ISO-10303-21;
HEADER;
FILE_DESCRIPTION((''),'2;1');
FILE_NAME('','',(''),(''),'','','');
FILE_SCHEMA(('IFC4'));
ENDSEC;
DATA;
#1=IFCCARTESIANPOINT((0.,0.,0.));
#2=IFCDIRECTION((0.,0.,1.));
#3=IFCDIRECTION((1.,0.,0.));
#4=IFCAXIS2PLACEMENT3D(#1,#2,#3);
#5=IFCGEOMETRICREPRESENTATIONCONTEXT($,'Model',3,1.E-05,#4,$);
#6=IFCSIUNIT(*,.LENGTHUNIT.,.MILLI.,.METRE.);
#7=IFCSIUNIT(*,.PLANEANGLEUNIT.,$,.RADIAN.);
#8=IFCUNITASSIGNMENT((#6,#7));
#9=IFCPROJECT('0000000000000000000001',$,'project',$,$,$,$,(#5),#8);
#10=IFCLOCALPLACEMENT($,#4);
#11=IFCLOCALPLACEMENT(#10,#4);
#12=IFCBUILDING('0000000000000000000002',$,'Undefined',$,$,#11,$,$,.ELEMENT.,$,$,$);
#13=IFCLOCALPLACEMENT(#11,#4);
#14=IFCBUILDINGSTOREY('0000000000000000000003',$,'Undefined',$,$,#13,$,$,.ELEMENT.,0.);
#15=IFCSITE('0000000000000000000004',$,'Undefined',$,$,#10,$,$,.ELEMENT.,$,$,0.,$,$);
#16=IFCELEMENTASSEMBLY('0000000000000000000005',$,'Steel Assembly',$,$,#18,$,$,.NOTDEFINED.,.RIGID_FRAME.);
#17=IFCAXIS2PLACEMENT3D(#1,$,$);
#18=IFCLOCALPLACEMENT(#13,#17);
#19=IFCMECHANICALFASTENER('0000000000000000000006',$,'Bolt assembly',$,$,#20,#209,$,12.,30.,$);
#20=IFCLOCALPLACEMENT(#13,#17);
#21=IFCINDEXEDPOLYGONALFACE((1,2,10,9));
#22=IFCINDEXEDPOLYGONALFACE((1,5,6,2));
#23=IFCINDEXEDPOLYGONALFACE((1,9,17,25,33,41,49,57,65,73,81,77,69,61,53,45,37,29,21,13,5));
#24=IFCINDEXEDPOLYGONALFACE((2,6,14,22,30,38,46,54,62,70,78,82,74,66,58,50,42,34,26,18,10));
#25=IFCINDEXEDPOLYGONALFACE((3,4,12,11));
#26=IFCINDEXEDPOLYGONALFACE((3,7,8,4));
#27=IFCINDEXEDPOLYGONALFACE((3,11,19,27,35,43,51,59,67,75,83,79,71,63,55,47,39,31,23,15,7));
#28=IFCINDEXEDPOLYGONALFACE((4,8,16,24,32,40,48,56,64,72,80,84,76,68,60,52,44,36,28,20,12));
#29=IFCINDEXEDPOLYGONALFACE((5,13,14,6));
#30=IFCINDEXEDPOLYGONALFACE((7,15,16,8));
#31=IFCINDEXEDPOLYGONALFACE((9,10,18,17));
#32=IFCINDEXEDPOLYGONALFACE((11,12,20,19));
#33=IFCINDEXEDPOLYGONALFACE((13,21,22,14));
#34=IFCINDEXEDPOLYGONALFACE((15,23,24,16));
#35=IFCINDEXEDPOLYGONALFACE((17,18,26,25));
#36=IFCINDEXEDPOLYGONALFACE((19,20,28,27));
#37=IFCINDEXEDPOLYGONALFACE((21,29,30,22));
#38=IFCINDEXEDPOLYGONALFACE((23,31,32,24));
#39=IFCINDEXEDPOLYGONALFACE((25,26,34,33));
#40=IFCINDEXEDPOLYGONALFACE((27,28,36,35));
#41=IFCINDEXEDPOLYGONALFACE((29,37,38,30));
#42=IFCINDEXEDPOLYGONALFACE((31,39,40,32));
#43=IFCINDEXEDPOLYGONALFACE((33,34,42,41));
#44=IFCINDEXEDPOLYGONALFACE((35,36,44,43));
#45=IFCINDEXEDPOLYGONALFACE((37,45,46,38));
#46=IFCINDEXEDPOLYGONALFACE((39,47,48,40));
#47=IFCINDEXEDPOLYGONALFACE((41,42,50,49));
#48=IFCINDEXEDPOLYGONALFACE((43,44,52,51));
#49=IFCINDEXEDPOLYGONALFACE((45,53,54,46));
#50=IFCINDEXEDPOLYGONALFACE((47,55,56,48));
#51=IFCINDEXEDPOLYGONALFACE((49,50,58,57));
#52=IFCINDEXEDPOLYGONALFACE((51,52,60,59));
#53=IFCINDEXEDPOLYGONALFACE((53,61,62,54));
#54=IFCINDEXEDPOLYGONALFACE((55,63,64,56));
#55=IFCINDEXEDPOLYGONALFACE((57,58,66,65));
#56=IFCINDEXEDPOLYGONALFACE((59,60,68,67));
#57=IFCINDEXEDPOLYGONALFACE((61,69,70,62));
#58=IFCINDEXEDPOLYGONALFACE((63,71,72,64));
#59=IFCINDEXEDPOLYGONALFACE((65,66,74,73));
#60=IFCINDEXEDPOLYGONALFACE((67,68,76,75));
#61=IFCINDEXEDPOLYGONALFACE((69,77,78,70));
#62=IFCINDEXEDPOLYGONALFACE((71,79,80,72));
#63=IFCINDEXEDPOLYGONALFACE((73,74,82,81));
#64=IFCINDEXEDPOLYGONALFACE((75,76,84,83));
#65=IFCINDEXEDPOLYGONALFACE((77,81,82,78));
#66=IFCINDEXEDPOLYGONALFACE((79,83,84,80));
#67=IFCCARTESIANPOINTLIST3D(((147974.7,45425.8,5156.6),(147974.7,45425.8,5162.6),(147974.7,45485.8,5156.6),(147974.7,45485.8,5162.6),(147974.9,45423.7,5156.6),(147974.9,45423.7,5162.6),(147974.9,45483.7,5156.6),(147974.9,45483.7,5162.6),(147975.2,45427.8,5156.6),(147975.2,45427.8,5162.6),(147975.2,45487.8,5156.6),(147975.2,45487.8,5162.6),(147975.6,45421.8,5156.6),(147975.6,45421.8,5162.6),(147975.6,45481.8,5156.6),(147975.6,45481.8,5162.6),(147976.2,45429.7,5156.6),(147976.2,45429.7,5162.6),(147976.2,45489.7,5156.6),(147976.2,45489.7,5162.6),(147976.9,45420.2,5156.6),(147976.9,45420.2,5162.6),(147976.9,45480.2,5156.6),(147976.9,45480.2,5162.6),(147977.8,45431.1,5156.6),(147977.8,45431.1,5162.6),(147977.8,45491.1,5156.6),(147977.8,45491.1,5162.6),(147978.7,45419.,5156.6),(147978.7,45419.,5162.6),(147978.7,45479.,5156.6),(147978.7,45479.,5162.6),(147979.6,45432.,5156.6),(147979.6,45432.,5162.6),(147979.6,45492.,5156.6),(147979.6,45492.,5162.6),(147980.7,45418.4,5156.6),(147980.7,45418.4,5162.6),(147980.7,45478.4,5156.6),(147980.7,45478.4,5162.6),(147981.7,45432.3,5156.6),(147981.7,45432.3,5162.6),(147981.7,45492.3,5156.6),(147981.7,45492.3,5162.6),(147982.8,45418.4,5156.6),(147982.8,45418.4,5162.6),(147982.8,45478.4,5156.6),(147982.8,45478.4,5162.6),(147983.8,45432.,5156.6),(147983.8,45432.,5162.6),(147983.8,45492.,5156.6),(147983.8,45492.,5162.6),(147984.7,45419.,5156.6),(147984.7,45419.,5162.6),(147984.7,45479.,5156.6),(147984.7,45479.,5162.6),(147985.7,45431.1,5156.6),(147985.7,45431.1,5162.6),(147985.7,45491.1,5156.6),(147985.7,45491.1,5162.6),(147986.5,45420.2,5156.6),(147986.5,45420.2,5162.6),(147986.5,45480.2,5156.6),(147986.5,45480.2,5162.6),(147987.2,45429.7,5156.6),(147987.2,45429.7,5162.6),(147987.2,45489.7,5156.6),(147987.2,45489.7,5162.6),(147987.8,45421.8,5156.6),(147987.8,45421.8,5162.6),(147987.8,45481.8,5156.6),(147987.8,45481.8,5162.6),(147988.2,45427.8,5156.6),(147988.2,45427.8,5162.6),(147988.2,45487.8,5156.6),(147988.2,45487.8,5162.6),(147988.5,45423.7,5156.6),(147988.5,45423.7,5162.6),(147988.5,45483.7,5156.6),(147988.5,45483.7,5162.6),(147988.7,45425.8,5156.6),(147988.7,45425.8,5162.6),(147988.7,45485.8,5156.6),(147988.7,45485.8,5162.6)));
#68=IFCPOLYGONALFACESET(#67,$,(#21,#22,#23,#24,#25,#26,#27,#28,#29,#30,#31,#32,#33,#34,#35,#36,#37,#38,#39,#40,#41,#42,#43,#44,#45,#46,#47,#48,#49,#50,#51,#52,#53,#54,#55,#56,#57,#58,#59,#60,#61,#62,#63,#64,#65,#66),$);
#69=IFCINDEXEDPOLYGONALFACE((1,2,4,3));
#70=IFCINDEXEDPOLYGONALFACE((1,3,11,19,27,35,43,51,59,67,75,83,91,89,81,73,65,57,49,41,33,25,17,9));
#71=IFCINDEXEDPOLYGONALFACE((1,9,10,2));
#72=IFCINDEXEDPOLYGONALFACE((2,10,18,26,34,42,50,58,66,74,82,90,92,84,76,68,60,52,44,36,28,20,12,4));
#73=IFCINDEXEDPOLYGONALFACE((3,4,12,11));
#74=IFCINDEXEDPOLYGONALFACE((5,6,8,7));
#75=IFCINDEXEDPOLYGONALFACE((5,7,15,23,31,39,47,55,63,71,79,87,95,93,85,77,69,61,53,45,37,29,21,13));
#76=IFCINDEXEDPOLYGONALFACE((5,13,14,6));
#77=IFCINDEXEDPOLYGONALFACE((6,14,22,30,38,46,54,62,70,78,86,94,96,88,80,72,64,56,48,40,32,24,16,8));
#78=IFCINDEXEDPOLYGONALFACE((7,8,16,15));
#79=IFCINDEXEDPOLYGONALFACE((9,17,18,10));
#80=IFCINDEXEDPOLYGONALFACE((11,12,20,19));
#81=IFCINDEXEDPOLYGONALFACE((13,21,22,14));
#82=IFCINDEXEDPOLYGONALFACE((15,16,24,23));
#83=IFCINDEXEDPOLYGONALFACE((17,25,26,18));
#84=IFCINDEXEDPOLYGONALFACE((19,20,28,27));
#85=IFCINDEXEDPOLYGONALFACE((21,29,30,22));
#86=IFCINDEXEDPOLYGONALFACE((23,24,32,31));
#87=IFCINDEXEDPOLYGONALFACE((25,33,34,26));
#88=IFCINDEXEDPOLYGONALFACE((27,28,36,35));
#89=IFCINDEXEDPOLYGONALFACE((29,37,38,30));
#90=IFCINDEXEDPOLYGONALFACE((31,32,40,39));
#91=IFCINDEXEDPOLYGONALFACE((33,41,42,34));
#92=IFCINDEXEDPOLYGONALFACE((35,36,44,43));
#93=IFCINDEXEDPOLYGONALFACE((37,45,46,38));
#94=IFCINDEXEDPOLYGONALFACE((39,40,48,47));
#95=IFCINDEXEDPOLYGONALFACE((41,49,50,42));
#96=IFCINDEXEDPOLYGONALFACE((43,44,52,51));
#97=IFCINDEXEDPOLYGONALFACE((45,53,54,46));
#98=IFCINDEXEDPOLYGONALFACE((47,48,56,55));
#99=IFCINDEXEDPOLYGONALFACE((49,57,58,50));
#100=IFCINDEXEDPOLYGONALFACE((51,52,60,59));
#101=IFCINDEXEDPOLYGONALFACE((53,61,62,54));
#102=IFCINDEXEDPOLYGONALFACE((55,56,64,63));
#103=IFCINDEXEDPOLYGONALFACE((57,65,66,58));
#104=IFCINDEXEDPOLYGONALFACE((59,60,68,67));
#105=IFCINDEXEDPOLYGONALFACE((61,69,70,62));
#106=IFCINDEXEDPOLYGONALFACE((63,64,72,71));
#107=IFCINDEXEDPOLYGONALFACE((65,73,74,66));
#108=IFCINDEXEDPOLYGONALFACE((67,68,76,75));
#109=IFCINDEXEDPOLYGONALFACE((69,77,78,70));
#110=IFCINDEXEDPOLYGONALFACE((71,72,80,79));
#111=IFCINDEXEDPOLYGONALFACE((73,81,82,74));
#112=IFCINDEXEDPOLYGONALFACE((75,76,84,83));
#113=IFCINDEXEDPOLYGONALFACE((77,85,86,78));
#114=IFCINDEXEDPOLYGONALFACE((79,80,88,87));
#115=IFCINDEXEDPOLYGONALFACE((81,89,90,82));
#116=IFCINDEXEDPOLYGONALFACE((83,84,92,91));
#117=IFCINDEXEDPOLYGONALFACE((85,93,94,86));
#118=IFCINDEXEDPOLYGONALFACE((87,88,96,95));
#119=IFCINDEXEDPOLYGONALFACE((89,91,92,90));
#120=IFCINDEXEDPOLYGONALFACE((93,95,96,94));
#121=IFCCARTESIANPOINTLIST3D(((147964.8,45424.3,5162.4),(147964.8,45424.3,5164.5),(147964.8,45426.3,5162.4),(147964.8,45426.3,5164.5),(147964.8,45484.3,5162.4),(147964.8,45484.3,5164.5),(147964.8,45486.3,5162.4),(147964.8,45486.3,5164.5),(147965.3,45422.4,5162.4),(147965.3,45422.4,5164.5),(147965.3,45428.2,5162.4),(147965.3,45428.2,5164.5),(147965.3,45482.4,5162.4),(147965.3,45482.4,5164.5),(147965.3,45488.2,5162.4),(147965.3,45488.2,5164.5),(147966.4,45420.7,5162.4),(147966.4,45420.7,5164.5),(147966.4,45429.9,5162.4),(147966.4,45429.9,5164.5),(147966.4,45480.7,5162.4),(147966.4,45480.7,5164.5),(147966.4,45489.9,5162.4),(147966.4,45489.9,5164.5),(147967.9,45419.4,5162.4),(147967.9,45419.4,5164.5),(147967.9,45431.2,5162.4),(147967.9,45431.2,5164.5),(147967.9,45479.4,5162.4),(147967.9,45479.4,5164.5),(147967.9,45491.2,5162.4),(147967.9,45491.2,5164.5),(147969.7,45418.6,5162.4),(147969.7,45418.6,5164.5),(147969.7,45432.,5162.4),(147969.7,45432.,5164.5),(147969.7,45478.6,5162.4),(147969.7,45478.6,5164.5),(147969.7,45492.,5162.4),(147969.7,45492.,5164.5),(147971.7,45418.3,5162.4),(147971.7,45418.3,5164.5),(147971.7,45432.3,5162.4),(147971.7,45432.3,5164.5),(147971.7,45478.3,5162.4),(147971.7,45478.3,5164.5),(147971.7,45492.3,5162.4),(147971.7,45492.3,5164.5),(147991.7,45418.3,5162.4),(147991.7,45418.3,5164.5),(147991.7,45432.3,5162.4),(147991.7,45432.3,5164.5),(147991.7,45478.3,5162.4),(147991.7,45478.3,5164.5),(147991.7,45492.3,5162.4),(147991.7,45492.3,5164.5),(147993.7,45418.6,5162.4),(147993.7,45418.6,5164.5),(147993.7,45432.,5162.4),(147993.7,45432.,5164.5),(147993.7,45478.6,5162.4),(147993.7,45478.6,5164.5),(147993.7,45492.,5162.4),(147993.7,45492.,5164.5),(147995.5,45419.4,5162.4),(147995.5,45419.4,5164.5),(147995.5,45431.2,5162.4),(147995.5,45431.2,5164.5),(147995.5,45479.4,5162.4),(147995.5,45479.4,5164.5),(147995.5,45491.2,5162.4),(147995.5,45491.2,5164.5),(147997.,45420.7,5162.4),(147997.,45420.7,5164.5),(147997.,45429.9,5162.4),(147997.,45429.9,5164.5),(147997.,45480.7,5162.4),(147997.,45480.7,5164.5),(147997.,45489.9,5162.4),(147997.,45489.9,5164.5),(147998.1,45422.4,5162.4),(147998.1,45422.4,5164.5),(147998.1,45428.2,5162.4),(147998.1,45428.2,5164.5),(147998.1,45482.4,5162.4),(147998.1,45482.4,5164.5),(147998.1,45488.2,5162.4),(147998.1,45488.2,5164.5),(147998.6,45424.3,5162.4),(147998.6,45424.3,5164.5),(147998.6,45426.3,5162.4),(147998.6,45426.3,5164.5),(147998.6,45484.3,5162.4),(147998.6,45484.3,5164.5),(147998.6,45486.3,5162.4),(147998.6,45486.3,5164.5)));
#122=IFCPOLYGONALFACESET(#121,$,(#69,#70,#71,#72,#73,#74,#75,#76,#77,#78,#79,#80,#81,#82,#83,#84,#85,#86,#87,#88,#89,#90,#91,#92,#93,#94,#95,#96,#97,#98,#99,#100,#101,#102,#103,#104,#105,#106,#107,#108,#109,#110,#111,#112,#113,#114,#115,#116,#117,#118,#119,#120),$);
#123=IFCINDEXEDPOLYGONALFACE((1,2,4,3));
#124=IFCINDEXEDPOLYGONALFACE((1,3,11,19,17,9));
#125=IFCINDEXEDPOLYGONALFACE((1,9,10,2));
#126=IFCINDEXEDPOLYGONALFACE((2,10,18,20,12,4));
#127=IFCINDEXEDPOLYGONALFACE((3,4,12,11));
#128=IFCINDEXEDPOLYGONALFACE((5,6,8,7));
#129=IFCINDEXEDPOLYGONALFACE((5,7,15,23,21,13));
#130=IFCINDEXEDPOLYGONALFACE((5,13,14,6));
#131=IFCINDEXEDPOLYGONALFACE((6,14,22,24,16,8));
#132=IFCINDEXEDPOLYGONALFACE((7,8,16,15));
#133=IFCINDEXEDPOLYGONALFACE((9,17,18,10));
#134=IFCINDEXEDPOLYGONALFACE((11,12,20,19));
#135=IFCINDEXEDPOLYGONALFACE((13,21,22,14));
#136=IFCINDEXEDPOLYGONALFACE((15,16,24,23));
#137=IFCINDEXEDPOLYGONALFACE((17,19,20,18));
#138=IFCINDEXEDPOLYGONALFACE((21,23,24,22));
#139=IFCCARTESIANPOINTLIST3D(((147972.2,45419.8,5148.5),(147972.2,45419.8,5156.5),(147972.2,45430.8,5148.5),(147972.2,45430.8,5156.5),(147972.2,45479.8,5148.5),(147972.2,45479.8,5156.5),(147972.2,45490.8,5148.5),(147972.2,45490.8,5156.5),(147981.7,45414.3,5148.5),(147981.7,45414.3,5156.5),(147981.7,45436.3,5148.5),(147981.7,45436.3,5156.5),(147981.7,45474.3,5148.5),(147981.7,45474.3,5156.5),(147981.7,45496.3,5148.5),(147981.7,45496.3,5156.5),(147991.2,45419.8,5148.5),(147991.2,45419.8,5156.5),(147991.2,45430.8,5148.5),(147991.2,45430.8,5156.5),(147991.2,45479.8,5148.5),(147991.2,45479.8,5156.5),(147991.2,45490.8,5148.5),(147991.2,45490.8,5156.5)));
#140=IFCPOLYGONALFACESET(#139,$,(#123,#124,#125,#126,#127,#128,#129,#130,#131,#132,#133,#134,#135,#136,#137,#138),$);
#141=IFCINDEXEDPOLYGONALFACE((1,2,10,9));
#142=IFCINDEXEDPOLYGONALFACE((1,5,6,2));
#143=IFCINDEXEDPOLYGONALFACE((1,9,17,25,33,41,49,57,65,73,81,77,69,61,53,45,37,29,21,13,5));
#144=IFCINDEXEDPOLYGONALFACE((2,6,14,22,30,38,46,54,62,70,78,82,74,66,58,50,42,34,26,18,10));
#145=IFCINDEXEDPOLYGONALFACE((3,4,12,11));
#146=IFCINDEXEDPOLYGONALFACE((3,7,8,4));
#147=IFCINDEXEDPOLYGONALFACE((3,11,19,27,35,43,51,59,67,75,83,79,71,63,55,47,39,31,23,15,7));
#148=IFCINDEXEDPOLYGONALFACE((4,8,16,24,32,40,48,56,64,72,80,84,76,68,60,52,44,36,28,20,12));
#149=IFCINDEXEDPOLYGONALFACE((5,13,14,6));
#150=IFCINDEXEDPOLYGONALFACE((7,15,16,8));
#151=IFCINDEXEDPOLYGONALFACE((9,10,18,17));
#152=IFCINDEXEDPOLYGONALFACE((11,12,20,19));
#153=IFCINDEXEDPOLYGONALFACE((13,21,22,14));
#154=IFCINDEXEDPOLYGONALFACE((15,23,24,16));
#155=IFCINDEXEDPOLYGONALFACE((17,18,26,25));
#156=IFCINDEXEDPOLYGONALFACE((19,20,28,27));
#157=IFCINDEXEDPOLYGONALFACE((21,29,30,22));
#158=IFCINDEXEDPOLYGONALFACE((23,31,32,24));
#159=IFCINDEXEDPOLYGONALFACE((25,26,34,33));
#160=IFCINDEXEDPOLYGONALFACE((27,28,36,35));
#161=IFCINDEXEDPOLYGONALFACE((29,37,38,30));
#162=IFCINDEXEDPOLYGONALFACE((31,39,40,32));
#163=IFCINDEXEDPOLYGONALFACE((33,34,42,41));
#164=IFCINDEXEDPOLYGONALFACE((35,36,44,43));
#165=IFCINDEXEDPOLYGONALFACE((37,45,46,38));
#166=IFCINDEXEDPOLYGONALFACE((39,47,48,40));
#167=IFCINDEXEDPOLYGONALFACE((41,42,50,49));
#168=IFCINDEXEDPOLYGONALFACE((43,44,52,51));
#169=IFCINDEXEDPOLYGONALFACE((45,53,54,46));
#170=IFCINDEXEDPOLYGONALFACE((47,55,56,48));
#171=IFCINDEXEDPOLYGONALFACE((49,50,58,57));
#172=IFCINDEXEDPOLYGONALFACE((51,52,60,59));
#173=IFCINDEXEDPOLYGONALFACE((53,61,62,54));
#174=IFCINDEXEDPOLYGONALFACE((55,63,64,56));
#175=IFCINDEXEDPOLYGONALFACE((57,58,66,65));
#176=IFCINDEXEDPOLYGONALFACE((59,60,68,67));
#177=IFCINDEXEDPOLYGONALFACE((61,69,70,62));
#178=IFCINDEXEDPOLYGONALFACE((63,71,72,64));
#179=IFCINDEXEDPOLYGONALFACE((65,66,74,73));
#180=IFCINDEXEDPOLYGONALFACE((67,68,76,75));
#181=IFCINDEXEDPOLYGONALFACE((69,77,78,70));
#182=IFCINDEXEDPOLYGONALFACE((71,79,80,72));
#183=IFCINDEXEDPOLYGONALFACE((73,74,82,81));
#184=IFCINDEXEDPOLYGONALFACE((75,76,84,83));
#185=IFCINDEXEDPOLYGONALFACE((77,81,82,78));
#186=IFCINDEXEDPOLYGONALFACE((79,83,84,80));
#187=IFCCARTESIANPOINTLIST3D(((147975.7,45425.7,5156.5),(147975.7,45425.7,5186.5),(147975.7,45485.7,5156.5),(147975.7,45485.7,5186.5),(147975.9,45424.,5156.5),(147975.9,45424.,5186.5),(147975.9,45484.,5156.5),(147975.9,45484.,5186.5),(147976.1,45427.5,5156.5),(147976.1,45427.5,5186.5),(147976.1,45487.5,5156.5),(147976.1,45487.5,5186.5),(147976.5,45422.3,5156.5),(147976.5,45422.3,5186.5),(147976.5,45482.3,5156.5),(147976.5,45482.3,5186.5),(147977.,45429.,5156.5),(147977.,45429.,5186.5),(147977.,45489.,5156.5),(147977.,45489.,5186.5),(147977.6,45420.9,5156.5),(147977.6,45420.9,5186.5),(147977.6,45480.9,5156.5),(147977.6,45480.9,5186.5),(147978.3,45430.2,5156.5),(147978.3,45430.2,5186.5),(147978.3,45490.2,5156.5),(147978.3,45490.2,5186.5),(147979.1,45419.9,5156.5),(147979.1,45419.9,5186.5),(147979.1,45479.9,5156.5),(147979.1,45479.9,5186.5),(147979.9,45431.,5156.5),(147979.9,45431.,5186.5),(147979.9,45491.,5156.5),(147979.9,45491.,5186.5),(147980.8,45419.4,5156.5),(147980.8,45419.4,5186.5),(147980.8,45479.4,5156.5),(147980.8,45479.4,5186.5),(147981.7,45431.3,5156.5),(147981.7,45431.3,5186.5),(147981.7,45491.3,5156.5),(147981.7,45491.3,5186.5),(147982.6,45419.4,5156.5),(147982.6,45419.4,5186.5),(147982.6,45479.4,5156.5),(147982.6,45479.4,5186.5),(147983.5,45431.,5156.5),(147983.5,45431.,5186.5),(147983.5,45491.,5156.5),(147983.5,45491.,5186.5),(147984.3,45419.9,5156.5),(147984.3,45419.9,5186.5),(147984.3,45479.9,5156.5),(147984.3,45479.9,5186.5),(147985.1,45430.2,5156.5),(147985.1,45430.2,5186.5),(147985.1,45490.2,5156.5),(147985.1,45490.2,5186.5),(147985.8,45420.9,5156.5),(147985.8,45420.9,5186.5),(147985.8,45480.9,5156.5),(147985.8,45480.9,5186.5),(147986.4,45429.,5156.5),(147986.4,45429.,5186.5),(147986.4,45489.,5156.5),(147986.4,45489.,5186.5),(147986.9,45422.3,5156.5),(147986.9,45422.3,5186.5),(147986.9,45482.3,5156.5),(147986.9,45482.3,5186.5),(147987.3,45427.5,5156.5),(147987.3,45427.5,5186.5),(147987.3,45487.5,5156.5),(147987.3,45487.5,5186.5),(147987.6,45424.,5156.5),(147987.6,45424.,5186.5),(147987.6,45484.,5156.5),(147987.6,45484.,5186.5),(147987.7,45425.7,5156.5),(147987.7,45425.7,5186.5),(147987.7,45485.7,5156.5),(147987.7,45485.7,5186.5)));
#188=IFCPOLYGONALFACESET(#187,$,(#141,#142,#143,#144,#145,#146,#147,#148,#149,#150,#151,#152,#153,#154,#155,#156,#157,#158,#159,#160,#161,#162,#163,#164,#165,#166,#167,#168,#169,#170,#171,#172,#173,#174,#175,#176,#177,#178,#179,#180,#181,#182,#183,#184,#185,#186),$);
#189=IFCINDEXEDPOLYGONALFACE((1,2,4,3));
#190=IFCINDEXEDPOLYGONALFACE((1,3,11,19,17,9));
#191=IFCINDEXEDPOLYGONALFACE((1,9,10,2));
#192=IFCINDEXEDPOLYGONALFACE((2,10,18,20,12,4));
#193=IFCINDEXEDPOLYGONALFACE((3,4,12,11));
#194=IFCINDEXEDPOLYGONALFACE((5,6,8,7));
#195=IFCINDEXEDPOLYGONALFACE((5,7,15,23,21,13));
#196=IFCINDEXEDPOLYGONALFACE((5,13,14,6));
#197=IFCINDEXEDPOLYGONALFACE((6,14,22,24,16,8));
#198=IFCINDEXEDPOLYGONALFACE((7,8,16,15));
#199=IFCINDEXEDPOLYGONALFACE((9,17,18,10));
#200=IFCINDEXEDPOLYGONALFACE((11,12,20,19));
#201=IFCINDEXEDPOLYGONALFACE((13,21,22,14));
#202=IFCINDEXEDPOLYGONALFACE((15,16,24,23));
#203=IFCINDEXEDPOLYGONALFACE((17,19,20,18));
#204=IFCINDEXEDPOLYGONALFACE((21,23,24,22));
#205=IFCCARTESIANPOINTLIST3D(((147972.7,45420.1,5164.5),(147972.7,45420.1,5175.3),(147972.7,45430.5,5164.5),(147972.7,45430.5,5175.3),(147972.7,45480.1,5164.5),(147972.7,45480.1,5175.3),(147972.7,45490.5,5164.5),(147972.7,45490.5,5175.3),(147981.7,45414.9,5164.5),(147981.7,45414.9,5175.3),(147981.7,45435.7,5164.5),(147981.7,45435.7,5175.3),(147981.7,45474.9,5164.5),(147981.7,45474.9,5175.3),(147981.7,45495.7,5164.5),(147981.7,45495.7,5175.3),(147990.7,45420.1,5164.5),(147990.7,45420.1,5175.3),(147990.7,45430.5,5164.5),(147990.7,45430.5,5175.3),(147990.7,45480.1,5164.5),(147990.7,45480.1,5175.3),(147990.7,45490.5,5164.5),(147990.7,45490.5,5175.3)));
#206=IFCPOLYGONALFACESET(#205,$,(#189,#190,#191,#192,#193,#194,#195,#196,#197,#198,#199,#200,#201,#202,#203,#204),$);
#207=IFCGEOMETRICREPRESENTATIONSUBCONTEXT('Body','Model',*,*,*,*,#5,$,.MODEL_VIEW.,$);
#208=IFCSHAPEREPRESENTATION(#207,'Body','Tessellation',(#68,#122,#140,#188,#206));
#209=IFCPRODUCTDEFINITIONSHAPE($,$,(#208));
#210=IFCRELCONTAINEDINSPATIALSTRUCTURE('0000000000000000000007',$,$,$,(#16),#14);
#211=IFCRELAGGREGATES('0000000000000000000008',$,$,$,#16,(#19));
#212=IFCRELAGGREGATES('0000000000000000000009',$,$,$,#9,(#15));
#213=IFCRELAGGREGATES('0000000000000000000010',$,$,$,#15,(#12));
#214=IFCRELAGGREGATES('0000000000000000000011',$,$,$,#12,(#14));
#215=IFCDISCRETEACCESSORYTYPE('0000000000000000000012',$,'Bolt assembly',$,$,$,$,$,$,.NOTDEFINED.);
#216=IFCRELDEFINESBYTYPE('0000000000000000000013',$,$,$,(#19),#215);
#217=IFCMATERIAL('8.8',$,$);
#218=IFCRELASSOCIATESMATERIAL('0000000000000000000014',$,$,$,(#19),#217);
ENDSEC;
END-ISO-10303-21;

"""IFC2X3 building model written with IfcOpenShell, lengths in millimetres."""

from ifc_helpers import new_model, si_unit, frame, frame_2d, origin_with_axes, origin_2d_with_axis, place, context, subcontext, project, spatial, polyline, circle_curve, parameter, trimmed, segment, composite_curve, circle, outline, extrude, source, transform, mapped, material, type_object, element, aggregate, save


model = new_model("IFC2X3")

# Units and contexts
model_context = context("Model", 3, precision=1e-05, world=origin_with_axes())
body_context = subcontext(model_context, "Body", "Model", "MODEL_VIEW")
ifc_project = project(units=[si_unit("LENGTHUNIT", "METRE", prefix="MILLI"), si_unit("PLANEANGLEUNIT", "RADIAN")], contexts=[model_context])

# Site, building, storey
site_placement = place(None, origin_with_axes())
site = spatial("IfcSite", under=ifc_project, at=site_placement, Name="Undefined", CompositionType="ELEMENT", RefElevation=0.0)
building_placement = place(site_placement, origin_with_axes())
building = spatial("IfcBuilding", under=site, at=building_placement, Name="Undefined", CompositionType="ELEMENT")
storey_placement = place(building_placement, origin_with_axes())
storey = spatial("IfcBuildingStorey", under=building, at=storey_placement, Name="Undefined", CompositionType="ELEMENT", Elevation=0.0)

# Shared definitions
discrete_accessory_type_1 = type_object("IfcDiscreteAccessoryType", Name="Bolt assembly")
ifc_material_1 = material(Name="8.8")

# Element assembly, mechanical fastener
assembly_1_placement = place(storey_placement, origin_with_axes())
assembly_1 = element("IfcElementAssembly", 1, at=assembly_1_placement, inside=storey, Name="Steel Assembly", AssemblyPlace="NOTDEFINED", PredefinedType="RIGID_FRAME")
shared_shape_1 = source(origin_with_axes(), body_context, "Body", "SweptSolid", [
    extrude(circle(Radius=7.0, at=origin_2d_with_axis()), frame((0.0, -2.9, 0.0), z_axis=(0.0, 1.0, 0.0), x_axis=(1.0, 0.0, 0.0)), (0.0, 0.0, 1.0), 6.0),
    extrude(outline(composite_curve([segment(polyline([(7.0, 10.0), (7.0, -10.0)]), True, "CONTINUOUS"), segment(trimmed(circle_curve(frame_2d((0.0, -10.0), x_axis=(1.0, 0.0)), 7.0), [parameter(0.0)], [parameter(3.1416)], False, "PARAMETER"), True, "CONTINUOUS"), segment(polyline([(-7.0, -10.0), (-7.0, 10.0)]), True, "CONTINUOUS"), segment(trimmed(circle_curve(frame_2d((0.0, 10.0), x_axis=(-1.0, 0.0)), 7.0), [parameter(0.0)], [parameter(3.1416)], False, "PARAMETER"), True, "DISCONTINUOUS")], self_intersect=False)), frame((0.0, 2.9, 0.0), z_axis=(0.0, 1.0, 0.0), x_axis=(1.0, 0.0, 0.0)), (0.0, 0.0, 1.0), 2.1),
    extrude(outline(polyline([(11.0, 0.0), (5.5, 9.5), (-5.5, 9.5), (-11.0, 0.0), (-5.5, -9.5), (5.5, -9.5), (11.0, 0.0)])), frame((0.0, -11.0, 0.0), z_axis=(0.0, 1.0, 0.0), x_axis=(1.0, 0.0, 0.0)), (0.0, 0.0, 1.0), 8.0),
    extrude(circle(Radius=6.0, at=origin_2d_with_axis()), frame((0.0, -3.0, 0.0), z_axis=(0.0, 1.0, 0.0), x_axis=(1.0, 0.0, 0.0)), (0.0, 0.0, 1.0), 30.0),
    extrude(outline(polyline([(10.4, 0.0), (5.2, 9.0), (-5.2, 9.0), (-10.4, 0.0), (-5.2, -9.0), (5.2, -9.0), (10.4, 0.0)])), frame((0.0, 5.0, 0.0), z_axis=(0.0, 1.0, 0.0), x_axis=(1.0, 0.0, 0.0)), (0.0, 0.0, 1.0), 10.8),
])
mechanical_fastener_1_placement = place(assembly_1_placement, frame((147936.7, 45380.3, 5159.5), z_axis=(1.0, 0.0, 0.0), x_axis=(0.0, 1.0, 0.0)))
mechanical_fastener_1 = element("IfcMechanicalFastener", 2, at=mechanical_fastener_1_placement, type_object=discrete_accessory_type_1, material=ifc_material_1, Name="Bolt assembly", NominalDiameter=12.0, NominalLength=30.0, context=body_context, shape_type="MappedRepresentation", body=[
    mapped(shared_shape_1, transform((45.0, 0.0, 45.0))),
    mapped(shared_shape_1, transform((105.0, 0.0, 45.0))),
])
aggregate(assembly_1, [mechanical_fastener_1])

save(model, "model.ifc")
